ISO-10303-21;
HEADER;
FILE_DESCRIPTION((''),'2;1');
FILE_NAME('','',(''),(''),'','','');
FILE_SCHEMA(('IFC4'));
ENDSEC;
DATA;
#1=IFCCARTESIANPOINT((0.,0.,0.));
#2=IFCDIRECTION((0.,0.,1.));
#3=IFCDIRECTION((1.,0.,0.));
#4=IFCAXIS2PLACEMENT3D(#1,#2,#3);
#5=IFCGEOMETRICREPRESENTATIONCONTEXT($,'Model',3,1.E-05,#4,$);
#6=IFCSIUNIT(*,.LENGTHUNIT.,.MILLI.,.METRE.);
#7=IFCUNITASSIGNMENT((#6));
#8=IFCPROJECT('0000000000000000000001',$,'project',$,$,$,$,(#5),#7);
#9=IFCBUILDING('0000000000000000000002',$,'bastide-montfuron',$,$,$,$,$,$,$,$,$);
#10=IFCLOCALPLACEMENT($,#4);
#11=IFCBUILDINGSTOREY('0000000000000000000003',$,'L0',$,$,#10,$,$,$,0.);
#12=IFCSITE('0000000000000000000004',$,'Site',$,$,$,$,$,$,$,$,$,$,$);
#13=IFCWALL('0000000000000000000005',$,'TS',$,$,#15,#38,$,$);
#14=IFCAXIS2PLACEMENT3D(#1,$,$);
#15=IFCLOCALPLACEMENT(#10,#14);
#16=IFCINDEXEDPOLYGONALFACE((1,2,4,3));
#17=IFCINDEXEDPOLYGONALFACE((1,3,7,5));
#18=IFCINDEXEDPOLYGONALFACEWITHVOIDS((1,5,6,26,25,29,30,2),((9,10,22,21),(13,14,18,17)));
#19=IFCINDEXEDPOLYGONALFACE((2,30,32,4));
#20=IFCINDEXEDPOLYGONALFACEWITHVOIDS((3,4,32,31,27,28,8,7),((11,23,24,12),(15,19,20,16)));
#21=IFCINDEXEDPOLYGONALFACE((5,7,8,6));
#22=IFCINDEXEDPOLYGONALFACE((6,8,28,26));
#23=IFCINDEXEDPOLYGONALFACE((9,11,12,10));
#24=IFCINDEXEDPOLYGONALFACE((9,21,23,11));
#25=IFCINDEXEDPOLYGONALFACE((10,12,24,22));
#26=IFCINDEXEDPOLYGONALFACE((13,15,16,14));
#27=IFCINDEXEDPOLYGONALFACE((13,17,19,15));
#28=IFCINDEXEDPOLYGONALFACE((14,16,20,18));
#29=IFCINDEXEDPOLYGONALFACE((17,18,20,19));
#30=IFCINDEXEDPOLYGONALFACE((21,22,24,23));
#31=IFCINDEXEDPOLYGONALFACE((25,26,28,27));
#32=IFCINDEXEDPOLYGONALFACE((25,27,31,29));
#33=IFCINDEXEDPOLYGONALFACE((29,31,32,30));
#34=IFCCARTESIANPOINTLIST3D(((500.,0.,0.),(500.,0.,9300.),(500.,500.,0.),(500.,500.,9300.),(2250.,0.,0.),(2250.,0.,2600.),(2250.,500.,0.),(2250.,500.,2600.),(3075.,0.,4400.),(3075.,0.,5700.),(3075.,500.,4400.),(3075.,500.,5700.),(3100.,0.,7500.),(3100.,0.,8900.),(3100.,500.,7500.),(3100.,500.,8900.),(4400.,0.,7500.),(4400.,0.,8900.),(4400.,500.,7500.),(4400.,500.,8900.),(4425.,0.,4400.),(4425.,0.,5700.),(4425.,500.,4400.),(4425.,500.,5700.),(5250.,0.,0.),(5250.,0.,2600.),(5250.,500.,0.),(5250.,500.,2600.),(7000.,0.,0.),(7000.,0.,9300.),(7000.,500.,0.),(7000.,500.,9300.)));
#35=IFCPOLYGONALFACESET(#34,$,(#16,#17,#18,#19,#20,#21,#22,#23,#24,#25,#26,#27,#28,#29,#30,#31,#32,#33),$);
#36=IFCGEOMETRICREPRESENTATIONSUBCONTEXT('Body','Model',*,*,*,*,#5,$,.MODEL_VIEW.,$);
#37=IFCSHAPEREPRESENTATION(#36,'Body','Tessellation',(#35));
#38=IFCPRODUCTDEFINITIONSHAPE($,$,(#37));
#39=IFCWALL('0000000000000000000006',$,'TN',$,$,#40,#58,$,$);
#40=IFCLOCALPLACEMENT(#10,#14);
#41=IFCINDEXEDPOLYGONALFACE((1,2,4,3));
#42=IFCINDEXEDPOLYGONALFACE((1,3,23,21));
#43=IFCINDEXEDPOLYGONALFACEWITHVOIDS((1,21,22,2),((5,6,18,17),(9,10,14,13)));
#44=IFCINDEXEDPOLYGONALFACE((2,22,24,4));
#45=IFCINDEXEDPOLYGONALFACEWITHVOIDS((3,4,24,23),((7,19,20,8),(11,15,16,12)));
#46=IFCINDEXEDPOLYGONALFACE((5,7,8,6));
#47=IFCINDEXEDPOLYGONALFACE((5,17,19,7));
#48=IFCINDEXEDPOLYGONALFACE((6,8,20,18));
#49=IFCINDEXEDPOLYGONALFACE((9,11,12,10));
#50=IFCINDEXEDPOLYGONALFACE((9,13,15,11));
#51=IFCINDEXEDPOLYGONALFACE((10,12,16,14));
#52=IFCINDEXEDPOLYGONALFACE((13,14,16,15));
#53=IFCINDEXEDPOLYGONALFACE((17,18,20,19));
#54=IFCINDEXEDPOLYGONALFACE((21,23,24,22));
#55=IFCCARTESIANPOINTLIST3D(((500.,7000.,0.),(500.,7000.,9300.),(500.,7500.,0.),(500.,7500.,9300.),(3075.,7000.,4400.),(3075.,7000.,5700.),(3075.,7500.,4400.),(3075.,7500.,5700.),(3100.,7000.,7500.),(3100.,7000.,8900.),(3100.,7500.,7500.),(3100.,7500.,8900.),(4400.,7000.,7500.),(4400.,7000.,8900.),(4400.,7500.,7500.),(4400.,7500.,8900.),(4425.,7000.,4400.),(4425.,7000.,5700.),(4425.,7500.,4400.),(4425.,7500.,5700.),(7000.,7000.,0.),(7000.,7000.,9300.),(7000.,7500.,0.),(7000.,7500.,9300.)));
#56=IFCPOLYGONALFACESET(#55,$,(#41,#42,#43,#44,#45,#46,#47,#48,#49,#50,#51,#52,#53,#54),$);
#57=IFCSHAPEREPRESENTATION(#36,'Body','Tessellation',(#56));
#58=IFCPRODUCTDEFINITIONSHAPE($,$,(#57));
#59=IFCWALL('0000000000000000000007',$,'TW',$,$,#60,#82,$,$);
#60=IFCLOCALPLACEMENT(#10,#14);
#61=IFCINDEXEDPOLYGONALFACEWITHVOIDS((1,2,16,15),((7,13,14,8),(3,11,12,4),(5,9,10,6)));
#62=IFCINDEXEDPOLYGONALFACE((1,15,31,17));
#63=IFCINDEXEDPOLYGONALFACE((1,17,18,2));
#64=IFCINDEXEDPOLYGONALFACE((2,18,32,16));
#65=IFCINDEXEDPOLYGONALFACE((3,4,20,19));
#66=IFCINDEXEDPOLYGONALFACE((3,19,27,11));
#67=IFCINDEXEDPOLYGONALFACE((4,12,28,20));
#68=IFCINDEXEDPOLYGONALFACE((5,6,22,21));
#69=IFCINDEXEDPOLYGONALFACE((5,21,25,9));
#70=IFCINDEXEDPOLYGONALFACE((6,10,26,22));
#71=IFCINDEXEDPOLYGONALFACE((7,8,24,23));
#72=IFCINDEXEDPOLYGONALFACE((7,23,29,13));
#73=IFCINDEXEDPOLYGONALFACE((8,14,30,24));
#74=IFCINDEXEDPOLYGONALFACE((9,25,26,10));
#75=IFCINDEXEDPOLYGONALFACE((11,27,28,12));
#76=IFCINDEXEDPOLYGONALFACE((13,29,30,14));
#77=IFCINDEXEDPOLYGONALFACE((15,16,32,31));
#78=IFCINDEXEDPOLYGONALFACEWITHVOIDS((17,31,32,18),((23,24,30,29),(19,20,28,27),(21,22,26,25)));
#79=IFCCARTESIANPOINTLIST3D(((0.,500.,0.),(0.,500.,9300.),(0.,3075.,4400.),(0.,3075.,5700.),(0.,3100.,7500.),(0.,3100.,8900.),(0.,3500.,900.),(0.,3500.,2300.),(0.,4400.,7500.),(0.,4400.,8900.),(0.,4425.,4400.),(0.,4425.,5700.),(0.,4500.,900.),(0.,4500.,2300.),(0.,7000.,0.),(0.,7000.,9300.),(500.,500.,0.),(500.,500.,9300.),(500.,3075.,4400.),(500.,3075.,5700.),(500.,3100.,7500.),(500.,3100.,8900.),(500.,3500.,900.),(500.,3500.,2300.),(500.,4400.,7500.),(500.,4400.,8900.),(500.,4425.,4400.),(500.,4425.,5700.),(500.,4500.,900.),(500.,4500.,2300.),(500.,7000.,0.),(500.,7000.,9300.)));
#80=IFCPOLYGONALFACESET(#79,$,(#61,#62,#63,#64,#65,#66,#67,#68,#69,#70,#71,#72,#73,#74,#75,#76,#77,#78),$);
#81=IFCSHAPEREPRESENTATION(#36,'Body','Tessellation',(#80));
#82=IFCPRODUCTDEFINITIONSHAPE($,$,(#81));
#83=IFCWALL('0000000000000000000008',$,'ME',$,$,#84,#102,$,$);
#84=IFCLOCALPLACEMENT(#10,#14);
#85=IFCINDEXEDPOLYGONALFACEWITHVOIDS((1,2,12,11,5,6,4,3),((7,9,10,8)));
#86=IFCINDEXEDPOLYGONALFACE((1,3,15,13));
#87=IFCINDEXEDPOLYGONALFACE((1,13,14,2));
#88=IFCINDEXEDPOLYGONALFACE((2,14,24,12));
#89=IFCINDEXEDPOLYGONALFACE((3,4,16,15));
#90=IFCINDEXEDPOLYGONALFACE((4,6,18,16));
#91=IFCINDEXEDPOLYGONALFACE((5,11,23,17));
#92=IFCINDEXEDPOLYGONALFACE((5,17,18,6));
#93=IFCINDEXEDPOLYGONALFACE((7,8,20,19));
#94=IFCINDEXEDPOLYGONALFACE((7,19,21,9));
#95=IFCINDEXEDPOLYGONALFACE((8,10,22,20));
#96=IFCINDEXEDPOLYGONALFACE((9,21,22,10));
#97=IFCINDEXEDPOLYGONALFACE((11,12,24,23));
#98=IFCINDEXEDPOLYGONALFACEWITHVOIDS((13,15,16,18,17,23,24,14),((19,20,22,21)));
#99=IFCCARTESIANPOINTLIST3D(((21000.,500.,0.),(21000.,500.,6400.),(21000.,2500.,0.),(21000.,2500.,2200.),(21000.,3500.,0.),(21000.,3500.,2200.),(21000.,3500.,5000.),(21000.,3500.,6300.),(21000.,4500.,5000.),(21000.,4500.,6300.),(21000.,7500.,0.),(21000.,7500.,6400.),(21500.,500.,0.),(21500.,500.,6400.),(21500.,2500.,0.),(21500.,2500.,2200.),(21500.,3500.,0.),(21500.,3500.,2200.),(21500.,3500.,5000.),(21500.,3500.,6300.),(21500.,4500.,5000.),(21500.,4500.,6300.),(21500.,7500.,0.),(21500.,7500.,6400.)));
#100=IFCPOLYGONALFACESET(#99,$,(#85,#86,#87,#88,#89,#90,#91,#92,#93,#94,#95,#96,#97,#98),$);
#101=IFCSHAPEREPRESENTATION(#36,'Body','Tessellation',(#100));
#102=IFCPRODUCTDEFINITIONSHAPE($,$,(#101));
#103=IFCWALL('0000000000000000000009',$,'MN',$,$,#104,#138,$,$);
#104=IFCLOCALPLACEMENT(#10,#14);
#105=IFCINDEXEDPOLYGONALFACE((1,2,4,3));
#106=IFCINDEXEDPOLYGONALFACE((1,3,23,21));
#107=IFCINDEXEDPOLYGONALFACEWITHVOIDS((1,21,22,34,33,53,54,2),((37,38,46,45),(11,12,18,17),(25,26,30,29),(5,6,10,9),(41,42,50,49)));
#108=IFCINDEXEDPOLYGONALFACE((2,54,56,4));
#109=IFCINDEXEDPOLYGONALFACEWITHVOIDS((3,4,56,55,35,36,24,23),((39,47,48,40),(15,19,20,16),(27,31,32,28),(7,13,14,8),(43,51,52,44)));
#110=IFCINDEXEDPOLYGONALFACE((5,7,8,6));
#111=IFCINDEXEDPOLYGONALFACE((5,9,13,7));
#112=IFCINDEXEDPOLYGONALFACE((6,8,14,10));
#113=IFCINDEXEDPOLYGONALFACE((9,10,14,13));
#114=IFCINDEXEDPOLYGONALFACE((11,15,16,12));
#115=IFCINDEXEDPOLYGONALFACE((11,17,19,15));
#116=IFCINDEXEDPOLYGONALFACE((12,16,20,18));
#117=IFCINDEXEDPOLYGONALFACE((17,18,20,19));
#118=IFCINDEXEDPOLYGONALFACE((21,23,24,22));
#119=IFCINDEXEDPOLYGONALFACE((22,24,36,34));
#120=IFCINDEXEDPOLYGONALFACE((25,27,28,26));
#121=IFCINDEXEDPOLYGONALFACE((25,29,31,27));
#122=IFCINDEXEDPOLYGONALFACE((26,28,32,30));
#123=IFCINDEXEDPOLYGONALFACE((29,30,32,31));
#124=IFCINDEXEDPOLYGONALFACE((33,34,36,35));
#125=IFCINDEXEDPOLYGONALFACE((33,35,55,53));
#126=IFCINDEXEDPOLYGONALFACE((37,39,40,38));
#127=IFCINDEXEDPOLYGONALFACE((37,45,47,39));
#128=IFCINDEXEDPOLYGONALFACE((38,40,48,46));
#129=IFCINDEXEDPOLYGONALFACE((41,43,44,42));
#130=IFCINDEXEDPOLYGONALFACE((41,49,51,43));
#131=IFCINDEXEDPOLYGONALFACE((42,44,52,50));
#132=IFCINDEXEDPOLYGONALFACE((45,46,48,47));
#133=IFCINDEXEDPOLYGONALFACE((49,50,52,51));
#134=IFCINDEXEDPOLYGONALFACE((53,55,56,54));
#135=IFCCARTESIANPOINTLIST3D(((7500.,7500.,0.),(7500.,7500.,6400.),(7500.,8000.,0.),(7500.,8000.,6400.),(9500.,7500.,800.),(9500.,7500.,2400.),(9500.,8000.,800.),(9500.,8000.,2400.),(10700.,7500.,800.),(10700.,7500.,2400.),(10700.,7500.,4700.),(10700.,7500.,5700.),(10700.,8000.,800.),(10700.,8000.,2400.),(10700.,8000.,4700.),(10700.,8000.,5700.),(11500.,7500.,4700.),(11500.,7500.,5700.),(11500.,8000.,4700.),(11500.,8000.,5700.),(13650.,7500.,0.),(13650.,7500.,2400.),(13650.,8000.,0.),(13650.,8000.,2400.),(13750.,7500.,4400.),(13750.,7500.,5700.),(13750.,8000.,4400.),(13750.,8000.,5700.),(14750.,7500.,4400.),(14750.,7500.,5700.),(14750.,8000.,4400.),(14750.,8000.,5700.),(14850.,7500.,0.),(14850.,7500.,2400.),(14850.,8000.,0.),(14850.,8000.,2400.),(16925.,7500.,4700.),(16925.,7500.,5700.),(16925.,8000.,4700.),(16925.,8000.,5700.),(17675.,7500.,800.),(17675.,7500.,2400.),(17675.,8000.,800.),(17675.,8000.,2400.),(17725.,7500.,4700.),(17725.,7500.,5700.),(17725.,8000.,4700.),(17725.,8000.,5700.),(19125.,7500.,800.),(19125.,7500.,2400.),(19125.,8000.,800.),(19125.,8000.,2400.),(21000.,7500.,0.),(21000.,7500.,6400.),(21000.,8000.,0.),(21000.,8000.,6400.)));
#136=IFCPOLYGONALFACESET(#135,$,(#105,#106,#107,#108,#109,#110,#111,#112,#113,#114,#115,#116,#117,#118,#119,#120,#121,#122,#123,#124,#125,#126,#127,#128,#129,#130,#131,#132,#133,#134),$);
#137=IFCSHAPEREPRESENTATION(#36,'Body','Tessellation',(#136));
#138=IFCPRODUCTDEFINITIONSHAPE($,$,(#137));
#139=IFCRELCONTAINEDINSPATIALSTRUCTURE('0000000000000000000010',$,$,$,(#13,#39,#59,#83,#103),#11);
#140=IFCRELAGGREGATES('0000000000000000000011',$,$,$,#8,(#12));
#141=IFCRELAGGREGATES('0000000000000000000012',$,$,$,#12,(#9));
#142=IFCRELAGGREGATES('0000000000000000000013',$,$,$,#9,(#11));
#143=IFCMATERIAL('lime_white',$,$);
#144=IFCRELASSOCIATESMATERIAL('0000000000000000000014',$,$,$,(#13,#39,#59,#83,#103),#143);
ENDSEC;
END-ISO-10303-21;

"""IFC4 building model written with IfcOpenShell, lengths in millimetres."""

from ifc_helpers import new_model, si_unit, frame, origin_with_axes, place, context, subcontext, project, spatial, indexed_curve, outline, extrude, material, element, save


model = new_model("IFC4")

# Units and contexts
model_context = context("Model", 3, precision=1e-05, world=origin_with_axes())
body_context = subcontext(model_context, "Body", "Model", "MODEL_VIEW")
ifc_project = project(units=[si_unit("LENGTHUNIT", "METRE", prefix="MILLI")], contexts=[model_context])

# Site, building, storey
site = spatial("IfcSite", under=ifc_project, Name="Site")
building = spatial("IfcBuilding", under=site, Name="bastide-montfuron")
storey_placement = place(None, origin_with_axes())
storey = spatial("IfcBuildingStorey", under=building, at=storey_placement, Name="L0", Elevation=0.0)

# Walls, openings
ifc_material = material(Name="lime_white")
wall_1_placement = place(storey_placement, frame((500.0, 0.0, 0.0), z_axis=(0.0, 0.0, 1.0), x_axis=(1.0, 0.0, 0.0)))
wall_1 = element("IfcWall", 1, at=wall_1_placement, inside=storey, material=ifc_material, Name="TS", context=body_context, shape_type="SweptSolid", body=[
    extrude(outline(indexed_curve([(0.0, 0.0), (0.0, 500.0), (6500.0, 500.0), (6500.0, 0.0), (0.0, 0.0)], self_intersect=False)), origin_with_axes(), (0.0, 0.0, 1.0), 9300.0),
])
opening_1_placement = place(wall_1_placement, frame((1750.0, -100.0, 0.0), z_axis=(0.0, 0.0, 1.0), x_axis=(1.0, 0.0, 0.0)))
element("IfcOpeningElement", 2, at=opening_1_placement, cuts=wall_1, context=body_context, shape_type="SweptSolid", body=[
    extrude(outline(indexed_curve([(0.0, 0.0), (0.0, 700.0), (3000.0, 700.0), (3000.0, 0.0), (0.0, 0.0)], self_intersect=False)), origin_with_axes(), (0.0, 0.0, 1.0), 2600.0),
])
opening_2_placement = place(wall_1_placement, frame((2575.0, -100.0, 4400.0), z_axis=(0.0, 0.0, 1.0), x_axis=(1.0, 0.0, 0.0)))
element("IfcOpeningElement", 3, at=opening_2_placement, cuts=wall_1, context=body_context, shape_type="SweptSolid", body=[
    extrude(outline(indexed_curve([(0.0, 0.0), (0.0, 700.0), (1350.0, 700.0), (1350.0, 0.0), (0.0, 0.0)], self_intersect=False)), origin_with_axes(), (0.0, 0.0, 1.0), 1300.0),
])
opening_3_placement = place(wall_1_placement, frame((2600.0, -100.0, 7500.0), z_axis=(0.0, 0.0, 1.0), x_axis=(1.0, 0.0, 0.0)))
element("IfcOpeningElement", 4, at=opening_3_placement, cuts=wall_1, context=body_context, shape_type="SweptSolid", body=[
    extrude(outline(indexed_curve([(0.0, 0.0), (0.0, 700.0), (1300.0, 700.0), (1300.0, 0.0), (0.0, 0.0)], self_intersect=False)), origin_with_axes(), (0.0, 0.0, 1.0), 1400.0),
])
wall_2_placement = place(storey_placement, frame((7000.0, 7500.0, 0.0), z_axis=(0.0, 0.0, 1.0), x_axis=(-1.0, 0.0, 0.0)))
wall_2 = element("IfcWall", 5, at=wall_2_placement, inside=storey, material=ifc_material, Name="TN", context=body_context, shape_type="SweptSolid", body=[
    extrude(outline(indexed_curve([(0.0, 0.0), (0.0, 500.0), (6500.0, 500.0), (6500.0, 0.0), (0.0, 0.0)], self_intersect=False)), origin_with_axes(), (0.0, 0.0, 1.0), 9300.0),
])
opening_4_placement = place(wall_2_placement, frame((2575.0, -100.0, 4400.0), z_axis=(0.0, 0.0, 1.0), x_axis=(1.0, 0.0, 0.0)))
element("IfcOpeningElement", 6, at=opening_4_placement, cuts=wall_2, context=body_context, shape_type="SweptSolid", body=[
    extrude(outline(indexed_curve([(0.0, 0.0), (0.0, 700.0), (1350.0, 700.0), (1350.0, 0.0), (0.0, 0.0)], self_intersect=False)), origin_with_axes(), (0.0, 0.0, 1.0), 1300.0),
])
opening_5_placement = place(wall_2_placement, frame((2600.0, -100.0, 7500.0), z_axis=(0.0, 0.0, 1.0), x_axis=(1.0, 0.0, 0.0)))
element("IfcOpeningElement", 7, at=opening_5_placement, cuts=wall_2, context=body_context, shape_type="SweptSolid", body=[
    extrude(outline(indexed_curve([(0.0, 0.0), (0.0, 700.0), (1300.0, 700.0), (1300.0, 0.0), (0.0, 0.0)], self_intersect=False)), origin_with_axes(), (0.0, 0.0, 1.0), 1400.0),
])
wall_3_placement = place(storey_placement, frame((0.0, 7000.0, 0.0), z_axis=(0.0, 0.0, 1.0), x_axis=(0.0, -1.0, 0.0)))
wall_3 = element("IfcWall", 8, at=wall_3_placement, inside=storey, material=ifc_material, Name="TW", context=body_context, shape_type="SweptSolid", body=[
    extrude(outline(indexed_curve([(0.0, 0.0), (0.0, 500.0), (6500.0, 500.0), (6500.0, 0.0), (0.0, 0.0)], self_intersect=False)), origin_with_axes(), (0.0, 0.0, 1.0), 9300.0),
])
opening_6_placement = place(wall_3_placement, frame((2500.0, -100.0, 900.0), z_axis=(0.0, 0.0, 1.0), x_axis=(1.0, 0.0, 0.0)))
element("IfcOpeningElement", 9, at=opening_6_placement, cuts=wall_3, context=body_context, shape_type="SweptSolid", body=[
    extrude(outline(indexed_curve([(0.0, 0.0), (0.0, 700.0), (1000.0, 700.0), (1000.0, 0.0), (0.0, 0.0)], self_intersect=False)), origin_with_axes(), (0.0, 0.0, 1.0), 1400.0),
])
opening_7_placement = place(wall_3_placement, frame((2575.0, -100.0, 4400.0), z_axis=(0.0, 0.0, 1.0), x_axis=(1.0, 0.0, 0.0)))
element("IfcOpeningElement", 10, at=opening_7_placement, cuts=wall_3, context=body_context, shape_type="SweptSolid", body=[
    extrude(outline(indexed_curve([(0.0, 0.0), (0.0, 700.0), (1350.0, 700.0), (1350.0, 0.0), (0.0, 0.0)], self_intersect=False)), origin_with_axes(), (0.0, 0.0, 1.0), 1300.0),
])
opening_8_placement = place(wall_3_placement, frame((2600.0, -100.0, 7500.0), z_axis=(0.0, 0.0, 1.0), x_axis=(1.0, 0.0, 0.0)))
element("IfcOpeningElement", 11, at=opening_8_placement, cuts=wall_3, context=body_context, shape_type="SweptSolid", body=[
    extrude(outline(indexed_curve([(0.0, 0.0), (0.0, 700.0), (1300.0, 700.0), (1300.0, 0.0), (0.0, 0.0)], self_intersect=False)), origin_with_axes(), (0.0, 0.0, 1.0), 1400.0),
])
wall_4_placement = place(storey_placement, frame((21500.0, 500.0, 0.0), z_axis=(0.0, 0.0, 1.0), x_axis=(0.0, 1.0, 0.0)))
wall_4 = element("IfcWall", 12, at=wall_4_placement, inside=storey, material=ifc_material, Name="ME", context=body_context, shape_type="SweptSolid", body=[
    extrude(outline(indexed_curve([(0.0, 0.0), (0.0, 500.0), (7000.0, 500.0), (7000.0, 0.0), (0.0, 0.0)], self_intersect=False)), origin_with_axes(), (0.0, 0.0, 1.0), 6400.0),
])
opening_9_placement = place(wall_4_placement, frame((3000.0, -100.0, 5000.0), z_axis=(0.0, 0.0, 1.0), x_axis=(1.0, 0.0, 0.0)))
element("IfcOpeningElement", 13, at=opening_9_placement, cuts=wall_4, context=body_context, shape_type="SweptSolid", body=[
    extrude(outline(indexed_curve([(0.0, 0.0), (0.0, 700.0), (1000.0, 700.0), (1000.0, 0.0), (0.0, 0.0)], self_intersect=False)), origin_with_axes(), (0.0, 0.0, 1.0), 1300.0),
])
opening_10_placement = place(wall_4_placement, frame((2000.0, -100.0, 0.0), z_axis=(0.0, 0.0, 1.0), x_axis=(1.0, 0.0, 0.0)))
element("IfcOpeningElement", 14, at=opening_10_placement, cuts=wall_4, context=body_context, shape_type="SweptSolid", body=[
    extrude(outline(indexed_curve([(0.0, 0.0), (0.0, 700.0), (1000.0, 700.0), (1000.0, 0.0), (0.0, 0.0)], self_intersect=False)), origin_with_axes(), (0.0, 0.0, 1.0), 2200.0),
])
wall_5_placement = place(storey_placement, frame((21000.0, 8000.0, 0.0), z_axis=(0.0, 0.0, 1.0), x_axis=(-1.0, 0.0, 0.0)))
wall_5 = element("IfcWall", 15, at=wall_5_placement, inside=storey, material=ifc_material, Name="MN", context=body_context, shape_type="SweptSolid", body=[
    extrude(outline(indexed_curve([(0.0, 0.0), (0.0, 500.0), (13500.0, 500.0), (13500.0, 0.0), (0.0, 0.0)], self_intersect=False)), origin_with_axes(), (0.0, 0.0, 1.0), 6400.0),
])
opening_11_placement = place(wall_5_placement, frame((6150.0, -100.0, 0.0), z_axis=(0.0, 0.0, 1.0), x_axis=(1.0, 0.0, 0.0)))
element("IfcOpeningElement", 16, at=opening_11_placement, cuts=wall_5, context=body_context, shape_type="SweptSolid", body=[
    extrude(outline(indexed_curve([(0.0, 0.0), (0.0, 700.0), (1200.0, 700.0), (1200.0, 0.0), (0.0, 0.0)], self_intersect=False)), origin_with_axes(), (0.0, 0.0, 1.0), 2400.0),
])
opening_12_placement = place(wall_5_placement, frame((1875.0, -100.0, 800.0), z_axis=(0.0, 0.0, 1.0), x_axis=(1.0, 0.0, 0.0)))
element("IfcOpeningElement", 17, at=opening_12_placement, cuts=wall_5, context=body_context, shape_type="SweptSolid", body=[
    extrude(outline(indexed_curve([(0.0, 0.0), (0.0, 700.0), (1450.0, 700.0), (1450.0, 0.0), (0.0, 0.0)], self_intersect=False)), origin_with_axes(), (0.0, 0.0, 1.0), 1600.0),
])
opening_13_placement = place(wall_5_placement, frame((10300.0, -100.0, 800.0), z_axis=(0.0, 0.0, 1.0), x_axis=(1.0, 0.0, 0.0)))
element("IfcOpeningElement", 18, at=opening_13_placement, cuts=wall_5, context=body_context, shape_type="SweptSolid", body=[
    extrude(outline(indexed_curve([(0.0, 0.0), (0.0, 700.0), (1200.0, 700.0), (1200.0, 0.0), (0.0, 0.0)], self_intersect=False)), origin_with_axes(), (0.0, 0.0, 1.0), 1600.0),
])
opening_14_placement = place(wall_5_placement, frame((3275.0, -100.0, 4700.0), z_axis=(0.0, 0.0, 1.0), x_axis=(1.0, 0.0, 0.0)))
element("IfcOpeningElement", 19, at=opening_14_placement, cuts=wall_5, context=body_context, shape_type="SweptSolid", body=[
    extrude(outline(indexed_curve([(0.0, 0.0), (0.0, 700.0), (800.0, 700.0), (800.0, 0.0), (0.0, 0.0)], self_intersect=False)), origin_with_axes(), (0.0, 0.0, 1.0), 1000.0),
])
opening_15_placement = place(wall_5_placement, frame((6250.0, -100.0, 4400.0), z_axis=(0.0, 0.0, 1.0), x_axis=(1.0, 0.0, 0.0)))
element("IfcOpeningElement", 20, at=opening_15_placement, cuts=wall_5, context=body_context, shape_type="SweptSolid", body=[
    extrude(outline(indexed_curve([(0.0, 0.0), (0.0, 700.0), (1000.0, 700.0), (1000.0, 0.0), (0.0, 0.0)], self_intersect=False)), origin_with_axes(), (0.0, 0.0, 1.0), 1300.0),
])
opening_16_placement = place(wall_5_placement, frame((9500.0, -100.0, 4700.0), z_axis=(0.0, 0.0, 1.0), x_axis=(1.0, 0.0, 0.0)))
element("IfcOpeningElement", 21, at=opening_16_placement, cuts=wall_5, context=body_context, shape_type="SweptSolid", body=[
    extrude(outline(indexed_curve([(0.0, 0.0), (0.0, 700.0), (800.0, 700.0), (800.0, 0.0), (0.0, 0.0)], self_intersect=False)), origin_with_axes(), (0.0, 0.0, 1.0), 1000.0),
])

save(model, "model.ifc")
